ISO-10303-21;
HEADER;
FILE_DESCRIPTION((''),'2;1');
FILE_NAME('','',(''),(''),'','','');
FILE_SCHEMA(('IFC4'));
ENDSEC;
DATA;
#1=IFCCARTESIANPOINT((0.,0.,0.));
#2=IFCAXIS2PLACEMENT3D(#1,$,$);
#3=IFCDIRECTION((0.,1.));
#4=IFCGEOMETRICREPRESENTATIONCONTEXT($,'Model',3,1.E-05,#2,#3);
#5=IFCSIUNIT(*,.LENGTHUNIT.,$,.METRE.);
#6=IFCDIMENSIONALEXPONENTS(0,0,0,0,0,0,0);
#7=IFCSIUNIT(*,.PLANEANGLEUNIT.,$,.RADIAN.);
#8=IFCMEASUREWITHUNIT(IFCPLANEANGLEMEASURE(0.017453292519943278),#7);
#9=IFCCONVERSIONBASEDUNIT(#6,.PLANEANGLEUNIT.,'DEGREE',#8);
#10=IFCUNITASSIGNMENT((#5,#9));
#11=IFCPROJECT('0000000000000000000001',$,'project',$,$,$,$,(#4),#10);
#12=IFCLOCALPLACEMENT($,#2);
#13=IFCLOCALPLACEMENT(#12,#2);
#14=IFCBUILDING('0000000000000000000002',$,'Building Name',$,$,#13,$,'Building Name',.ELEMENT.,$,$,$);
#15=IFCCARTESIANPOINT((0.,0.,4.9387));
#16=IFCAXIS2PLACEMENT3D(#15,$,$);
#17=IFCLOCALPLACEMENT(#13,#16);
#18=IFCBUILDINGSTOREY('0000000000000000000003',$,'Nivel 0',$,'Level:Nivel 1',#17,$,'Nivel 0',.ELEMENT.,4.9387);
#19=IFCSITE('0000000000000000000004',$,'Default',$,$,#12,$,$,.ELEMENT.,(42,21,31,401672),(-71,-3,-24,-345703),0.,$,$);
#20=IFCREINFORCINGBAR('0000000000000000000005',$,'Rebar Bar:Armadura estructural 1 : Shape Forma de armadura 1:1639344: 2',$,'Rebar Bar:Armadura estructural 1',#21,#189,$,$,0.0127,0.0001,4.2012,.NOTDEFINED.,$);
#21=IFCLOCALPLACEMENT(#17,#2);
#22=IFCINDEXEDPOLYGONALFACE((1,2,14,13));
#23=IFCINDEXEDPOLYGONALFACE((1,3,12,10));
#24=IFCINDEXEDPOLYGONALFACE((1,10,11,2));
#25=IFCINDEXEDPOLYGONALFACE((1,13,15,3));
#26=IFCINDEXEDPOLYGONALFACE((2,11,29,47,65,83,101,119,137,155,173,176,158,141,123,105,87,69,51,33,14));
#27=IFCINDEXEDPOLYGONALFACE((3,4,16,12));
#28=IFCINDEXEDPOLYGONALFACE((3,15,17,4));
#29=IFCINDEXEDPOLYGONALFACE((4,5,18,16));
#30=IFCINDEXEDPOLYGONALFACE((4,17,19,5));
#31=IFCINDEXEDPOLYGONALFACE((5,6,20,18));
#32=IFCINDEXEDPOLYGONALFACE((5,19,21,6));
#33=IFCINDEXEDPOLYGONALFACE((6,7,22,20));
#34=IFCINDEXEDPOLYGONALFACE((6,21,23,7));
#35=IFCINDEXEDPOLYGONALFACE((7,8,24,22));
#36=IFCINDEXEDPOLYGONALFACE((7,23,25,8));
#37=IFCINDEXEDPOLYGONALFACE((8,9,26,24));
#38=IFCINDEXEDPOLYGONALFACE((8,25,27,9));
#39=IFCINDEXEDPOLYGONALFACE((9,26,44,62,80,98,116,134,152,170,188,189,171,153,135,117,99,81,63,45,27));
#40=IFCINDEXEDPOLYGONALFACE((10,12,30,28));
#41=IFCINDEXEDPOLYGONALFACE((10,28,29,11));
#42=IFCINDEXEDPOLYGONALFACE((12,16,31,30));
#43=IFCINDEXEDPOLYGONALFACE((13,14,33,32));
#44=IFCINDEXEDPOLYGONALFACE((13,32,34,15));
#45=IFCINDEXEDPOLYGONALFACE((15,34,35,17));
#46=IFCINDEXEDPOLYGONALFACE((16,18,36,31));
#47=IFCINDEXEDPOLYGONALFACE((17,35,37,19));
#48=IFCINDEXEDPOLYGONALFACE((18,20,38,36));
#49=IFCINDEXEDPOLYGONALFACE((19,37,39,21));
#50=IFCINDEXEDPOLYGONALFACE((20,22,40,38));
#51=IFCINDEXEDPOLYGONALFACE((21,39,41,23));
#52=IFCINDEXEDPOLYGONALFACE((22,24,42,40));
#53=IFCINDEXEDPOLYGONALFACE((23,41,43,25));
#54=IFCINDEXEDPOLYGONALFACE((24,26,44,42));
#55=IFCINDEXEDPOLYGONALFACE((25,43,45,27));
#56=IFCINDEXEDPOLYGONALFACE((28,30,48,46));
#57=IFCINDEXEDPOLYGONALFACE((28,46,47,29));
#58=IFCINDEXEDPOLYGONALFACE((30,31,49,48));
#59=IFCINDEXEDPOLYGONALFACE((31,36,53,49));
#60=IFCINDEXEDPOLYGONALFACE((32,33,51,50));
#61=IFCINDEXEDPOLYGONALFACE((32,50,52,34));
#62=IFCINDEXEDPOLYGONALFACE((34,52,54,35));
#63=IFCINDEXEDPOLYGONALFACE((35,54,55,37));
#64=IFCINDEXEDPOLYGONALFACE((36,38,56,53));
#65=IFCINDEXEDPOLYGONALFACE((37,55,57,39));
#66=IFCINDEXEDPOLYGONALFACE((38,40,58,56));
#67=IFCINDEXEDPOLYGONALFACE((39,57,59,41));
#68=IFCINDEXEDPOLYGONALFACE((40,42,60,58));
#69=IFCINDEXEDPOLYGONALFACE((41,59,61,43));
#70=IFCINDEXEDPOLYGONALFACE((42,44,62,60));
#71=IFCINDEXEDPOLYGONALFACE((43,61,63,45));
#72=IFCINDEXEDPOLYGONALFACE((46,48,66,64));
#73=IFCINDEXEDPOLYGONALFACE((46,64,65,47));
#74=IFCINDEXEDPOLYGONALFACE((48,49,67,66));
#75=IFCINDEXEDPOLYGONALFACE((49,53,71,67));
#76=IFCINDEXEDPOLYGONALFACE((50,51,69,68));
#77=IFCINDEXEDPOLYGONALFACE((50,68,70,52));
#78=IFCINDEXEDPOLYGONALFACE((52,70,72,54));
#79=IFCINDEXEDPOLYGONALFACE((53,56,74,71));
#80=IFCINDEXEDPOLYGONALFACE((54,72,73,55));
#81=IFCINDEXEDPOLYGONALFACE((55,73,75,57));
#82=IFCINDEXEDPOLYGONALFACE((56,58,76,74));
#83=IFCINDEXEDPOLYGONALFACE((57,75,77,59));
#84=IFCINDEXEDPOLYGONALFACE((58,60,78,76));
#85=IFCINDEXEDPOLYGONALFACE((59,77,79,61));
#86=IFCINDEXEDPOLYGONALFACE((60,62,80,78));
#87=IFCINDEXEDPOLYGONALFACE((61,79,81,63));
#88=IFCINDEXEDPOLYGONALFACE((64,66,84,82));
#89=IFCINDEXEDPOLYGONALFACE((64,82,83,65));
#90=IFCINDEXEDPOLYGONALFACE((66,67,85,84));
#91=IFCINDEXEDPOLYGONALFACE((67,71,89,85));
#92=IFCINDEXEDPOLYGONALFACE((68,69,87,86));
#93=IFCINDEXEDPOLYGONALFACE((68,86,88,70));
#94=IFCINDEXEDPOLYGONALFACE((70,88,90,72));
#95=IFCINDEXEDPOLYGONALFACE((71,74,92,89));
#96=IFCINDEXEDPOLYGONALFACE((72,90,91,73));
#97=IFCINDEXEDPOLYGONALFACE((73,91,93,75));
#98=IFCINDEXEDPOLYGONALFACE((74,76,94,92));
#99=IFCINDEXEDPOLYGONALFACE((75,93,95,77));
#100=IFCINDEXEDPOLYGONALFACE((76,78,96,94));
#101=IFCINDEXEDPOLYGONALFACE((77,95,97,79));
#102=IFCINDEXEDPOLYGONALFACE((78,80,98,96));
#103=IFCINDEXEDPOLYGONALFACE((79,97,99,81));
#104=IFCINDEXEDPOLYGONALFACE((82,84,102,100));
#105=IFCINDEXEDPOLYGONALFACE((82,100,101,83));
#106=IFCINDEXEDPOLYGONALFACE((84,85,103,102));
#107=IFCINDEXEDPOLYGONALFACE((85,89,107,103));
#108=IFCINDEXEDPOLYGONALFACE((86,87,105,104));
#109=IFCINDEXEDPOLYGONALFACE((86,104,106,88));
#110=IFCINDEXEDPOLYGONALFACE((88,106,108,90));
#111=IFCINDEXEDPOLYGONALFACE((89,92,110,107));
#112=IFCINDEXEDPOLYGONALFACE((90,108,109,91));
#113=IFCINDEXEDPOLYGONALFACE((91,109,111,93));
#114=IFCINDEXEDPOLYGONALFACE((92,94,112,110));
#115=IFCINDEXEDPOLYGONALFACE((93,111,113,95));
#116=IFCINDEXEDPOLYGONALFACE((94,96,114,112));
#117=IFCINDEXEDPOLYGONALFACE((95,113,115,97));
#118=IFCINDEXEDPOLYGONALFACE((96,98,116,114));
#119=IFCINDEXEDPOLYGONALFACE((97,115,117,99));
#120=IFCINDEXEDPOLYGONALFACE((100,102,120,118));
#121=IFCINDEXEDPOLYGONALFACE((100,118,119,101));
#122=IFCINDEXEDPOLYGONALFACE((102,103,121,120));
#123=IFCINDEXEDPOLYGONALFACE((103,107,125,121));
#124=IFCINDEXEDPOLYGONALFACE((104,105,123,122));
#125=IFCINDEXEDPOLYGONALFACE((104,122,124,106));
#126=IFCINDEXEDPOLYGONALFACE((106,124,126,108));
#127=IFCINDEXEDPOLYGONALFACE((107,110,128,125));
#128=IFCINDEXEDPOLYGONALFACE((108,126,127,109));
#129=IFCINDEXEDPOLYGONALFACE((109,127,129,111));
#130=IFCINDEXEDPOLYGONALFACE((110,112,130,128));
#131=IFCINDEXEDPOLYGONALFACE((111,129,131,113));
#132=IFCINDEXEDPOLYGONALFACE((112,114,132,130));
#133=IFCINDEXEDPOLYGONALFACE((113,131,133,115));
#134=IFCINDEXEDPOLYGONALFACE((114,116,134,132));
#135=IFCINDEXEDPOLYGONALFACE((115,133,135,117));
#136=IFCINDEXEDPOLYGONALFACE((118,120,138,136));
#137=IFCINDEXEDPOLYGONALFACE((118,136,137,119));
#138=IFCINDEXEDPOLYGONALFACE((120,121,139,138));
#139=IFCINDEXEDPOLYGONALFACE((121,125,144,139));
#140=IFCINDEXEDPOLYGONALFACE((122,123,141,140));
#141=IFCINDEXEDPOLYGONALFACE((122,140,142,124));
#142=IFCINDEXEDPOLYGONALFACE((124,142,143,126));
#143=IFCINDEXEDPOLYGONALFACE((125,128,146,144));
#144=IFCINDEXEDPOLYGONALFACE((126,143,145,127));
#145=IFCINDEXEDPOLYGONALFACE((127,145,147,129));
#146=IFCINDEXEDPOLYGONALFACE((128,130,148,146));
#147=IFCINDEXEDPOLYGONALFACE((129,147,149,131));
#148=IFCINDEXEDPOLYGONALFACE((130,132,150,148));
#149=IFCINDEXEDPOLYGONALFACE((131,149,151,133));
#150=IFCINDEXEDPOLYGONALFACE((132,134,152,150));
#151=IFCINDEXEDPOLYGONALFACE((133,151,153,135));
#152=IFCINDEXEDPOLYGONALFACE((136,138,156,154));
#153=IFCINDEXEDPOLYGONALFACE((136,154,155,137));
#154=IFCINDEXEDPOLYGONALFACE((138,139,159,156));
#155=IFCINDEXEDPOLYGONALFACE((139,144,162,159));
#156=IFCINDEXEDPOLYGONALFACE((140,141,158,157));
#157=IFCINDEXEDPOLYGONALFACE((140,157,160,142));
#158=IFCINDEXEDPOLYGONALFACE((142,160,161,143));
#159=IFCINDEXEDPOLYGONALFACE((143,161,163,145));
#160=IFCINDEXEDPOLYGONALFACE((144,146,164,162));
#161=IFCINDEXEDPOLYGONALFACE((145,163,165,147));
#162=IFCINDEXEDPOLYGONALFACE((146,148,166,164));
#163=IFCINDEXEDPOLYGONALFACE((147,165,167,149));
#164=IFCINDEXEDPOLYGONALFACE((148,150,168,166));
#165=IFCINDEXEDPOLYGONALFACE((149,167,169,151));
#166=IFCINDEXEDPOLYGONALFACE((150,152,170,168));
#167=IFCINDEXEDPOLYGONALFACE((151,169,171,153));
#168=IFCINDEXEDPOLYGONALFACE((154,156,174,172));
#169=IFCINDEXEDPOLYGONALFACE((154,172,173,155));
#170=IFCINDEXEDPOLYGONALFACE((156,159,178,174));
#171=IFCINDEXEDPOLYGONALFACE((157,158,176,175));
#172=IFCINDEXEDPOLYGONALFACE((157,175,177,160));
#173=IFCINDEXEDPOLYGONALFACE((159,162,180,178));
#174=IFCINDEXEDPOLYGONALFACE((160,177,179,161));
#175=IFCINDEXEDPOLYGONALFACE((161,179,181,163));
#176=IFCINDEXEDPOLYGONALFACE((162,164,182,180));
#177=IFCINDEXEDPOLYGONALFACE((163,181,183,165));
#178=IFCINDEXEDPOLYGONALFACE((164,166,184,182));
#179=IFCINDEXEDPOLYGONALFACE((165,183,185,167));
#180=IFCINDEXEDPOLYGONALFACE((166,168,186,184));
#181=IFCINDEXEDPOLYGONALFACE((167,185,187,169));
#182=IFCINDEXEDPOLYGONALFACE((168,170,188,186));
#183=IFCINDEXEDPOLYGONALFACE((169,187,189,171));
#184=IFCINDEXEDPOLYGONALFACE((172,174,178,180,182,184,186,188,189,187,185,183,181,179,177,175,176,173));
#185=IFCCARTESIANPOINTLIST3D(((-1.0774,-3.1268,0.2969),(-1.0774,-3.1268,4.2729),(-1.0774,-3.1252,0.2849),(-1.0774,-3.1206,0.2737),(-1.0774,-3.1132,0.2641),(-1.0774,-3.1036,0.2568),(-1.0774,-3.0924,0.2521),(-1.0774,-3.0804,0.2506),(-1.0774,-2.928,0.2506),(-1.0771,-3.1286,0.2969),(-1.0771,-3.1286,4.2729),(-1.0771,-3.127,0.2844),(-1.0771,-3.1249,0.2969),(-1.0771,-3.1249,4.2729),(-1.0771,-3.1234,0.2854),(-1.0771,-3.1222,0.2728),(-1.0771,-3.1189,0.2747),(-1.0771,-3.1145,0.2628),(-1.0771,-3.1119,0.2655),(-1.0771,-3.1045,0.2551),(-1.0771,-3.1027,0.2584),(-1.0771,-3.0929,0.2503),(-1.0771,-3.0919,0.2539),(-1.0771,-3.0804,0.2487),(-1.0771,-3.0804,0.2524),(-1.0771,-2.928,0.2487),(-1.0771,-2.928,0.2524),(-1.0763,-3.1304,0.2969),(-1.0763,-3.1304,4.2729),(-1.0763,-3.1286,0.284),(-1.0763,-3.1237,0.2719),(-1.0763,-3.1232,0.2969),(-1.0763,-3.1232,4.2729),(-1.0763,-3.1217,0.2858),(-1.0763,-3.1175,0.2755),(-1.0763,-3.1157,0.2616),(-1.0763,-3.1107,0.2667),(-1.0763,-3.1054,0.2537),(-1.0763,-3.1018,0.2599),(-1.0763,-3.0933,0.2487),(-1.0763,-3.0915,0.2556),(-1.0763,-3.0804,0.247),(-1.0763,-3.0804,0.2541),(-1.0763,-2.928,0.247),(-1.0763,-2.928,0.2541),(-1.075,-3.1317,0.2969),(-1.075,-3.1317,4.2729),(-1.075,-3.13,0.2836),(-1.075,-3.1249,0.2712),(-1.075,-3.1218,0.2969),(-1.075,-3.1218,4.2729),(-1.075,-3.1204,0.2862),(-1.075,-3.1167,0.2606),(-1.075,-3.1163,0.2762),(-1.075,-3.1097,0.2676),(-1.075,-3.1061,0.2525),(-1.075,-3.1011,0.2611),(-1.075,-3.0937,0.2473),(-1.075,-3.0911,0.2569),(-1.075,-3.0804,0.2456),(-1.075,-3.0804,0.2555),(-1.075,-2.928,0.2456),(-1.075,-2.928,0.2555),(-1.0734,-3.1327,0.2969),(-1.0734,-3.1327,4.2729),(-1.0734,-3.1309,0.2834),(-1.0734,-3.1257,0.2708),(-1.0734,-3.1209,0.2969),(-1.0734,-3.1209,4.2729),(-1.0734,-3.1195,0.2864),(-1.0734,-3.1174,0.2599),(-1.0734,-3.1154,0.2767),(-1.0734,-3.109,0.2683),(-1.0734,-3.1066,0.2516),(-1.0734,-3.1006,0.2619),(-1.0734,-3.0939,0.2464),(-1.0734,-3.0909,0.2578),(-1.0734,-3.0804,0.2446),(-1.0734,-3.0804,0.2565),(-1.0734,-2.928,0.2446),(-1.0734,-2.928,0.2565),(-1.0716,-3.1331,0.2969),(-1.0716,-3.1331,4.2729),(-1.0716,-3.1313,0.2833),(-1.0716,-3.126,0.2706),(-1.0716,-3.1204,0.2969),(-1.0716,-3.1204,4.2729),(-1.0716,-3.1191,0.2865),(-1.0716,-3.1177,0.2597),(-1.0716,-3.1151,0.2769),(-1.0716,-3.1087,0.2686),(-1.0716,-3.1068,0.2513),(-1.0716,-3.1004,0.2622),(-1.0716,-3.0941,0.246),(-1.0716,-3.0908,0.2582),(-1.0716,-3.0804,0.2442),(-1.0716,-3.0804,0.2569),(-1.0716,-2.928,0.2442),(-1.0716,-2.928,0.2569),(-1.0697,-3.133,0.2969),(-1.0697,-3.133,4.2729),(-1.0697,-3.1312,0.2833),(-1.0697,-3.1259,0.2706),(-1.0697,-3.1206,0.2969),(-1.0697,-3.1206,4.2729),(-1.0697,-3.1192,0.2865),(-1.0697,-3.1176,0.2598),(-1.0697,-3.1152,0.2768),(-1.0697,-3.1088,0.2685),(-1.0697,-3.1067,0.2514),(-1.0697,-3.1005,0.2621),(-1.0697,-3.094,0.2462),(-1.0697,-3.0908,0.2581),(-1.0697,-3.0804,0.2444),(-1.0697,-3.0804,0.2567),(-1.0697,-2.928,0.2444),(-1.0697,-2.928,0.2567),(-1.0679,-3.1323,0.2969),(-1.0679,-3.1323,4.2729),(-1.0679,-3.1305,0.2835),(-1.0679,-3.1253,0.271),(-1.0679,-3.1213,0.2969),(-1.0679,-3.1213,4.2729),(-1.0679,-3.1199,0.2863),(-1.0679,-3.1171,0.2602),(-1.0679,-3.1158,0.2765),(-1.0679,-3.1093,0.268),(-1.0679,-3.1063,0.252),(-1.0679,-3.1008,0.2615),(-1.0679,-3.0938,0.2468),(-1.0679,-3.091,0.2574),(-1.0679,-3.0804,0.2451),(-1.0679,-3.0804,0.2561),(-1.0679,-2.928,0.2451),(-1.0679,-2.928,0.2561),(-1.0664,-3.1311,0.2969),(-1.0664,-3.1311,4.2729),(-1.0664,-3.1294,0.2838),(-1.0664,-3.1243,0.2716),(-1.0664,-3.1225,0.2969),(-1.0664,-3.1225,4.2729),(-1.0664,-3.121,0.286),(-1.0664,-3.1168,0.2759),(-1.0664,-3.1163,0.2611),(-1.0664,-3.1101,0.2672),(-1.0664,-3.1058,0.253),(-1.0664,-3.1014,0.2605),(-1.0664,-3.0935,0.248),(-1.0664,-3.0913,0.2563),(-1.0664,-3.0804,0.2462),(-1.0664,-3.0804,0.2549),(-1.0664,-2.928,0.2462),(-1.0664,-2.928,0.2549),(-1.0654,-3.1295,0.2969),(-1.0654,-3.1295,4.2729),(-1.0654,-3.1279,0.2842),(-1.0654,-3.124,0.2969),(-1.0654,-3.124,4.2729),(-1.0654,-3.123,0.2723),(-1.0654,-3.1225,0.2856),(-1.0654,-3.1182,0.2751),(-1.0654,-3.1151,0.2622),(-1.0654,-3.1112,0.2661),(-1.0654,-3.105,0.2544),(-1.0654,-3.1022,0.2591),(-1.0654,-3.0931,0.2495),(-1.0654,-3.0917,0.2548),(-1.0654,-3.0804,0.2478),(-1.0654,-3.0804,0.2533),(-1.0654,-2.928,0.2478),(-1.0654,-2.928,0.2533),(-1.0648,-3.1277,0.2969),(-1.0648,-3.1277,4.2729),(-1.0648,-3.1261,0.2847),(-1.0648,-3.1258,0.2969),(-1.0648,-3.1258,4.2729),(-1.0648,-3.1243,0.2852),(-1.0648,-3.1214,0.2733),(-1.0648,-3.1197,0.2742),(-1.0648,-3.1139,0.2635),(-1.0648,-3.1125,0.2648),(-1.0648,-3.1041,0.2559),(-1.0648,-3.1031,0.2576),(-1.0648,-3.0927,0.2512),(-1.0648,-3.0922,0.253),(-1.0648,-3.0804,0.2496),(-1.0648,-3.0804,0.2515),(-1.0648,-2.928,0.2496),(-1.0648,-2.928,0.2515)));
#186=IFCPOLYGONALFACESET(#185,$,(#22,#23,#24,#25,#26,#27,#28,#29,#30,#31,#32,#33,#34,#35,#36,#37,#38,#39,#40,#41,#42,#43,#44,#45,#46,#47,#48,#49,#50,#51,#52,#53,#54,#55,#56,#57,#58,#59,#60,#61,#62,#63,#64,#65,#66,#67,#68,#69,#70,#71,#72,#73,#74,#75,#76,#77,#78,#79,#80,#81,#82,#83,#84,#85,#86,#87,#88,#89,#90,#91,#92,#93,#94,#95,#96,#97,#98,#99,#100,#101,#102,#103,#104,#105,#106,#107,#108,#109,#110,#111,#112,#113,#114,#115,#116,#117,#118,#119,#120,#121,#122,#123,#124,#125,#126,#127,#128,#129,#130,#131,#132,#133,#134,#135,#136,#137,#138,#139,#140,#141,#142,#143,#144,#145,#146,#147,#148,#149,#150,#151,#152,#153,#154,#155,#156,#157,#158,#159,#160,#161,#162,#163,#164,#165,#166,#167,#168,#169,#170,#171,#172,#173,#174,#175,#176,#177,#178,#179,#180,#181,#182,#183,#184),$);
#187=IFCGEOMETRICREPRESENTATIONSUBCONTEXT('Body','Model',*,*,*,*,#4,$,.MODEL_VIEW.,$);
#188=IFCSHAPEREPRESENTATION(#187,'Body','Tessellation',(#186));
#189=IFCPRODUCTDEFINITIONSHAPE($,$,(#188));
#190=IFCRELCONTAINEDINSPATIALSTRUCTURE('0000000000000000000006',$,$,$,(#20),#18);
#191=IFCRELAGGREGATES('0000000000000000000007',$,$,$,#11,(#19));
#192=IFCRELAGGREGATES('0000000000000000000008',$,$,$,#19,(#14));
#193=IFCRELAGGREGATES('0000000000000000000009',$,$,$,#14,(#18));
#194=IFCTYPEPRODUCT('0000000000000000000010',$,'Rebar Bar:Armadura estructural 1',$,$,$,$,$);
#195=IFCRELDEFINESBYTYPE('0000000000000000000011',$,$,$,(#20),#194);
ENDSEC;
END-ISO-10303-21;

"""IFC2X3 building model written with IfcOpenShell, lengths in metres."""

from ifc_helpers import new_model, entity, si_unit, converted_unit, direction, frame, origin, place, context, subcontext, project, spatial, type_object, element, save


model = new_model("IFC2X3")

# Units and contexts
model_context = context("Model", 3, precision=1e-05, world=origin(), true_north=direction((0.0, 1.0)))
body_context = subcontext(model_context, "Body", "Model", "MODEL_VIEW")
ifc_project = project(units=[si_unit("LENGTHUNIT", "METRE"), converted_unit("PLANEANGLEUNIT", "DEGREE", entity("IfcPlaneAngleMeasure", 0.017453292519943278), si_unit("PLANEANGLEUNIT", "RADIAN"), dimensions=[0, 0, 0, 0, 0, 0, 0])], contexts=[model_context])

# Site, building, storey
site_placement = place(None, origin())
site = spatial("IfcSite", under=ifc_project, at=site_placement, Name="Default", CompositionType="ELEMENT", RefLatitude=(42, 21, 31, 401672), RefLongitude=(-71, -3, -24, -345703), RefElevation=0.0)
building_placement = place(site_placement, origin())
building = spatial("IfcBuilding", under=site, at=building_placement, Name="Building Name", LongName="Building Name", CompositionType="ELEMENT")
storey_placement = place(building_placement, frame((0.0, 0.0, 4.9387)))
storey = spatial("IfcBuildingStorey", under=building, at=storey_placement, Name="Nivel 0", ObjectType="Level:Nivel 1", LongName="Nivel 0", CompositionType="ELEMENT", Elevation=4.9387)

# Reinforcing bar
type_product = type_object("IfcTypeProduct", Name="Rebar Bar:Armadura estructural 1")
reinforcing_bar_1_placement = place(storey_placement, origin())
element("IfcReinforcingBar", 1, at=reinforcing_bar_1_placement, inside=storey, type_object=type_product, Name="Rebar Bar:Armadura estructural 1 : Shape Forma de armadura 1:1639344: 2", ObjectType="Rebar Bar:Armadura estructural 1", BarLength=4.2012, BarRole="NOTDEFINED", CrossSectionArea=0.0001, NominalDiameter=0.0127, context=body_context, shape_type="AdvancedSweptSolid", body=[
    entity("IfcSweptDiskSolid", entity("IfcCompositeCurve", [entity("IfcCompositeCurveSegment", "CONTINUOUS", True, entity("IfcPolyline", [entity("IfcCartesianPoint", [-1.0711, -2.928, 0.2506]), entity("IfcCartesianPoint", [-1.0711, -3.0804, 0.2506])])), entity("IfcCompositeCurveSegment", "CONTINUOUS", True, entity("IfcTrimmedCurve", entity("IfcCircle", entity("IfcAxis2Placement3D", entity("IfcCartesianPoint", [-1.0711, -3.0804, 0.2969]), entity("IfcDirection", [-1.0, 0.0, 0.0]), entity("IfcDirection", [0.0, -1.0, 0.0])), 0.0464), [entity("IfcParameterValue", 270.0)], [entity("IfcParameterValue", 360.0)], True, "PARAMETER")), entity("IfcCompositeCurveSegment", "CONTINUOUS", True, entity("IfcPolyline", [entity("IfcCartesianPoint", [-1.0711, -3.1268, 0.2969]), entity("IfcCartesianPoint", [-1.0711, -3.1268, 4.2729])]))], False), 0.0063, None, 0.0, 92.0),
])

save(model, "model.ifc")
